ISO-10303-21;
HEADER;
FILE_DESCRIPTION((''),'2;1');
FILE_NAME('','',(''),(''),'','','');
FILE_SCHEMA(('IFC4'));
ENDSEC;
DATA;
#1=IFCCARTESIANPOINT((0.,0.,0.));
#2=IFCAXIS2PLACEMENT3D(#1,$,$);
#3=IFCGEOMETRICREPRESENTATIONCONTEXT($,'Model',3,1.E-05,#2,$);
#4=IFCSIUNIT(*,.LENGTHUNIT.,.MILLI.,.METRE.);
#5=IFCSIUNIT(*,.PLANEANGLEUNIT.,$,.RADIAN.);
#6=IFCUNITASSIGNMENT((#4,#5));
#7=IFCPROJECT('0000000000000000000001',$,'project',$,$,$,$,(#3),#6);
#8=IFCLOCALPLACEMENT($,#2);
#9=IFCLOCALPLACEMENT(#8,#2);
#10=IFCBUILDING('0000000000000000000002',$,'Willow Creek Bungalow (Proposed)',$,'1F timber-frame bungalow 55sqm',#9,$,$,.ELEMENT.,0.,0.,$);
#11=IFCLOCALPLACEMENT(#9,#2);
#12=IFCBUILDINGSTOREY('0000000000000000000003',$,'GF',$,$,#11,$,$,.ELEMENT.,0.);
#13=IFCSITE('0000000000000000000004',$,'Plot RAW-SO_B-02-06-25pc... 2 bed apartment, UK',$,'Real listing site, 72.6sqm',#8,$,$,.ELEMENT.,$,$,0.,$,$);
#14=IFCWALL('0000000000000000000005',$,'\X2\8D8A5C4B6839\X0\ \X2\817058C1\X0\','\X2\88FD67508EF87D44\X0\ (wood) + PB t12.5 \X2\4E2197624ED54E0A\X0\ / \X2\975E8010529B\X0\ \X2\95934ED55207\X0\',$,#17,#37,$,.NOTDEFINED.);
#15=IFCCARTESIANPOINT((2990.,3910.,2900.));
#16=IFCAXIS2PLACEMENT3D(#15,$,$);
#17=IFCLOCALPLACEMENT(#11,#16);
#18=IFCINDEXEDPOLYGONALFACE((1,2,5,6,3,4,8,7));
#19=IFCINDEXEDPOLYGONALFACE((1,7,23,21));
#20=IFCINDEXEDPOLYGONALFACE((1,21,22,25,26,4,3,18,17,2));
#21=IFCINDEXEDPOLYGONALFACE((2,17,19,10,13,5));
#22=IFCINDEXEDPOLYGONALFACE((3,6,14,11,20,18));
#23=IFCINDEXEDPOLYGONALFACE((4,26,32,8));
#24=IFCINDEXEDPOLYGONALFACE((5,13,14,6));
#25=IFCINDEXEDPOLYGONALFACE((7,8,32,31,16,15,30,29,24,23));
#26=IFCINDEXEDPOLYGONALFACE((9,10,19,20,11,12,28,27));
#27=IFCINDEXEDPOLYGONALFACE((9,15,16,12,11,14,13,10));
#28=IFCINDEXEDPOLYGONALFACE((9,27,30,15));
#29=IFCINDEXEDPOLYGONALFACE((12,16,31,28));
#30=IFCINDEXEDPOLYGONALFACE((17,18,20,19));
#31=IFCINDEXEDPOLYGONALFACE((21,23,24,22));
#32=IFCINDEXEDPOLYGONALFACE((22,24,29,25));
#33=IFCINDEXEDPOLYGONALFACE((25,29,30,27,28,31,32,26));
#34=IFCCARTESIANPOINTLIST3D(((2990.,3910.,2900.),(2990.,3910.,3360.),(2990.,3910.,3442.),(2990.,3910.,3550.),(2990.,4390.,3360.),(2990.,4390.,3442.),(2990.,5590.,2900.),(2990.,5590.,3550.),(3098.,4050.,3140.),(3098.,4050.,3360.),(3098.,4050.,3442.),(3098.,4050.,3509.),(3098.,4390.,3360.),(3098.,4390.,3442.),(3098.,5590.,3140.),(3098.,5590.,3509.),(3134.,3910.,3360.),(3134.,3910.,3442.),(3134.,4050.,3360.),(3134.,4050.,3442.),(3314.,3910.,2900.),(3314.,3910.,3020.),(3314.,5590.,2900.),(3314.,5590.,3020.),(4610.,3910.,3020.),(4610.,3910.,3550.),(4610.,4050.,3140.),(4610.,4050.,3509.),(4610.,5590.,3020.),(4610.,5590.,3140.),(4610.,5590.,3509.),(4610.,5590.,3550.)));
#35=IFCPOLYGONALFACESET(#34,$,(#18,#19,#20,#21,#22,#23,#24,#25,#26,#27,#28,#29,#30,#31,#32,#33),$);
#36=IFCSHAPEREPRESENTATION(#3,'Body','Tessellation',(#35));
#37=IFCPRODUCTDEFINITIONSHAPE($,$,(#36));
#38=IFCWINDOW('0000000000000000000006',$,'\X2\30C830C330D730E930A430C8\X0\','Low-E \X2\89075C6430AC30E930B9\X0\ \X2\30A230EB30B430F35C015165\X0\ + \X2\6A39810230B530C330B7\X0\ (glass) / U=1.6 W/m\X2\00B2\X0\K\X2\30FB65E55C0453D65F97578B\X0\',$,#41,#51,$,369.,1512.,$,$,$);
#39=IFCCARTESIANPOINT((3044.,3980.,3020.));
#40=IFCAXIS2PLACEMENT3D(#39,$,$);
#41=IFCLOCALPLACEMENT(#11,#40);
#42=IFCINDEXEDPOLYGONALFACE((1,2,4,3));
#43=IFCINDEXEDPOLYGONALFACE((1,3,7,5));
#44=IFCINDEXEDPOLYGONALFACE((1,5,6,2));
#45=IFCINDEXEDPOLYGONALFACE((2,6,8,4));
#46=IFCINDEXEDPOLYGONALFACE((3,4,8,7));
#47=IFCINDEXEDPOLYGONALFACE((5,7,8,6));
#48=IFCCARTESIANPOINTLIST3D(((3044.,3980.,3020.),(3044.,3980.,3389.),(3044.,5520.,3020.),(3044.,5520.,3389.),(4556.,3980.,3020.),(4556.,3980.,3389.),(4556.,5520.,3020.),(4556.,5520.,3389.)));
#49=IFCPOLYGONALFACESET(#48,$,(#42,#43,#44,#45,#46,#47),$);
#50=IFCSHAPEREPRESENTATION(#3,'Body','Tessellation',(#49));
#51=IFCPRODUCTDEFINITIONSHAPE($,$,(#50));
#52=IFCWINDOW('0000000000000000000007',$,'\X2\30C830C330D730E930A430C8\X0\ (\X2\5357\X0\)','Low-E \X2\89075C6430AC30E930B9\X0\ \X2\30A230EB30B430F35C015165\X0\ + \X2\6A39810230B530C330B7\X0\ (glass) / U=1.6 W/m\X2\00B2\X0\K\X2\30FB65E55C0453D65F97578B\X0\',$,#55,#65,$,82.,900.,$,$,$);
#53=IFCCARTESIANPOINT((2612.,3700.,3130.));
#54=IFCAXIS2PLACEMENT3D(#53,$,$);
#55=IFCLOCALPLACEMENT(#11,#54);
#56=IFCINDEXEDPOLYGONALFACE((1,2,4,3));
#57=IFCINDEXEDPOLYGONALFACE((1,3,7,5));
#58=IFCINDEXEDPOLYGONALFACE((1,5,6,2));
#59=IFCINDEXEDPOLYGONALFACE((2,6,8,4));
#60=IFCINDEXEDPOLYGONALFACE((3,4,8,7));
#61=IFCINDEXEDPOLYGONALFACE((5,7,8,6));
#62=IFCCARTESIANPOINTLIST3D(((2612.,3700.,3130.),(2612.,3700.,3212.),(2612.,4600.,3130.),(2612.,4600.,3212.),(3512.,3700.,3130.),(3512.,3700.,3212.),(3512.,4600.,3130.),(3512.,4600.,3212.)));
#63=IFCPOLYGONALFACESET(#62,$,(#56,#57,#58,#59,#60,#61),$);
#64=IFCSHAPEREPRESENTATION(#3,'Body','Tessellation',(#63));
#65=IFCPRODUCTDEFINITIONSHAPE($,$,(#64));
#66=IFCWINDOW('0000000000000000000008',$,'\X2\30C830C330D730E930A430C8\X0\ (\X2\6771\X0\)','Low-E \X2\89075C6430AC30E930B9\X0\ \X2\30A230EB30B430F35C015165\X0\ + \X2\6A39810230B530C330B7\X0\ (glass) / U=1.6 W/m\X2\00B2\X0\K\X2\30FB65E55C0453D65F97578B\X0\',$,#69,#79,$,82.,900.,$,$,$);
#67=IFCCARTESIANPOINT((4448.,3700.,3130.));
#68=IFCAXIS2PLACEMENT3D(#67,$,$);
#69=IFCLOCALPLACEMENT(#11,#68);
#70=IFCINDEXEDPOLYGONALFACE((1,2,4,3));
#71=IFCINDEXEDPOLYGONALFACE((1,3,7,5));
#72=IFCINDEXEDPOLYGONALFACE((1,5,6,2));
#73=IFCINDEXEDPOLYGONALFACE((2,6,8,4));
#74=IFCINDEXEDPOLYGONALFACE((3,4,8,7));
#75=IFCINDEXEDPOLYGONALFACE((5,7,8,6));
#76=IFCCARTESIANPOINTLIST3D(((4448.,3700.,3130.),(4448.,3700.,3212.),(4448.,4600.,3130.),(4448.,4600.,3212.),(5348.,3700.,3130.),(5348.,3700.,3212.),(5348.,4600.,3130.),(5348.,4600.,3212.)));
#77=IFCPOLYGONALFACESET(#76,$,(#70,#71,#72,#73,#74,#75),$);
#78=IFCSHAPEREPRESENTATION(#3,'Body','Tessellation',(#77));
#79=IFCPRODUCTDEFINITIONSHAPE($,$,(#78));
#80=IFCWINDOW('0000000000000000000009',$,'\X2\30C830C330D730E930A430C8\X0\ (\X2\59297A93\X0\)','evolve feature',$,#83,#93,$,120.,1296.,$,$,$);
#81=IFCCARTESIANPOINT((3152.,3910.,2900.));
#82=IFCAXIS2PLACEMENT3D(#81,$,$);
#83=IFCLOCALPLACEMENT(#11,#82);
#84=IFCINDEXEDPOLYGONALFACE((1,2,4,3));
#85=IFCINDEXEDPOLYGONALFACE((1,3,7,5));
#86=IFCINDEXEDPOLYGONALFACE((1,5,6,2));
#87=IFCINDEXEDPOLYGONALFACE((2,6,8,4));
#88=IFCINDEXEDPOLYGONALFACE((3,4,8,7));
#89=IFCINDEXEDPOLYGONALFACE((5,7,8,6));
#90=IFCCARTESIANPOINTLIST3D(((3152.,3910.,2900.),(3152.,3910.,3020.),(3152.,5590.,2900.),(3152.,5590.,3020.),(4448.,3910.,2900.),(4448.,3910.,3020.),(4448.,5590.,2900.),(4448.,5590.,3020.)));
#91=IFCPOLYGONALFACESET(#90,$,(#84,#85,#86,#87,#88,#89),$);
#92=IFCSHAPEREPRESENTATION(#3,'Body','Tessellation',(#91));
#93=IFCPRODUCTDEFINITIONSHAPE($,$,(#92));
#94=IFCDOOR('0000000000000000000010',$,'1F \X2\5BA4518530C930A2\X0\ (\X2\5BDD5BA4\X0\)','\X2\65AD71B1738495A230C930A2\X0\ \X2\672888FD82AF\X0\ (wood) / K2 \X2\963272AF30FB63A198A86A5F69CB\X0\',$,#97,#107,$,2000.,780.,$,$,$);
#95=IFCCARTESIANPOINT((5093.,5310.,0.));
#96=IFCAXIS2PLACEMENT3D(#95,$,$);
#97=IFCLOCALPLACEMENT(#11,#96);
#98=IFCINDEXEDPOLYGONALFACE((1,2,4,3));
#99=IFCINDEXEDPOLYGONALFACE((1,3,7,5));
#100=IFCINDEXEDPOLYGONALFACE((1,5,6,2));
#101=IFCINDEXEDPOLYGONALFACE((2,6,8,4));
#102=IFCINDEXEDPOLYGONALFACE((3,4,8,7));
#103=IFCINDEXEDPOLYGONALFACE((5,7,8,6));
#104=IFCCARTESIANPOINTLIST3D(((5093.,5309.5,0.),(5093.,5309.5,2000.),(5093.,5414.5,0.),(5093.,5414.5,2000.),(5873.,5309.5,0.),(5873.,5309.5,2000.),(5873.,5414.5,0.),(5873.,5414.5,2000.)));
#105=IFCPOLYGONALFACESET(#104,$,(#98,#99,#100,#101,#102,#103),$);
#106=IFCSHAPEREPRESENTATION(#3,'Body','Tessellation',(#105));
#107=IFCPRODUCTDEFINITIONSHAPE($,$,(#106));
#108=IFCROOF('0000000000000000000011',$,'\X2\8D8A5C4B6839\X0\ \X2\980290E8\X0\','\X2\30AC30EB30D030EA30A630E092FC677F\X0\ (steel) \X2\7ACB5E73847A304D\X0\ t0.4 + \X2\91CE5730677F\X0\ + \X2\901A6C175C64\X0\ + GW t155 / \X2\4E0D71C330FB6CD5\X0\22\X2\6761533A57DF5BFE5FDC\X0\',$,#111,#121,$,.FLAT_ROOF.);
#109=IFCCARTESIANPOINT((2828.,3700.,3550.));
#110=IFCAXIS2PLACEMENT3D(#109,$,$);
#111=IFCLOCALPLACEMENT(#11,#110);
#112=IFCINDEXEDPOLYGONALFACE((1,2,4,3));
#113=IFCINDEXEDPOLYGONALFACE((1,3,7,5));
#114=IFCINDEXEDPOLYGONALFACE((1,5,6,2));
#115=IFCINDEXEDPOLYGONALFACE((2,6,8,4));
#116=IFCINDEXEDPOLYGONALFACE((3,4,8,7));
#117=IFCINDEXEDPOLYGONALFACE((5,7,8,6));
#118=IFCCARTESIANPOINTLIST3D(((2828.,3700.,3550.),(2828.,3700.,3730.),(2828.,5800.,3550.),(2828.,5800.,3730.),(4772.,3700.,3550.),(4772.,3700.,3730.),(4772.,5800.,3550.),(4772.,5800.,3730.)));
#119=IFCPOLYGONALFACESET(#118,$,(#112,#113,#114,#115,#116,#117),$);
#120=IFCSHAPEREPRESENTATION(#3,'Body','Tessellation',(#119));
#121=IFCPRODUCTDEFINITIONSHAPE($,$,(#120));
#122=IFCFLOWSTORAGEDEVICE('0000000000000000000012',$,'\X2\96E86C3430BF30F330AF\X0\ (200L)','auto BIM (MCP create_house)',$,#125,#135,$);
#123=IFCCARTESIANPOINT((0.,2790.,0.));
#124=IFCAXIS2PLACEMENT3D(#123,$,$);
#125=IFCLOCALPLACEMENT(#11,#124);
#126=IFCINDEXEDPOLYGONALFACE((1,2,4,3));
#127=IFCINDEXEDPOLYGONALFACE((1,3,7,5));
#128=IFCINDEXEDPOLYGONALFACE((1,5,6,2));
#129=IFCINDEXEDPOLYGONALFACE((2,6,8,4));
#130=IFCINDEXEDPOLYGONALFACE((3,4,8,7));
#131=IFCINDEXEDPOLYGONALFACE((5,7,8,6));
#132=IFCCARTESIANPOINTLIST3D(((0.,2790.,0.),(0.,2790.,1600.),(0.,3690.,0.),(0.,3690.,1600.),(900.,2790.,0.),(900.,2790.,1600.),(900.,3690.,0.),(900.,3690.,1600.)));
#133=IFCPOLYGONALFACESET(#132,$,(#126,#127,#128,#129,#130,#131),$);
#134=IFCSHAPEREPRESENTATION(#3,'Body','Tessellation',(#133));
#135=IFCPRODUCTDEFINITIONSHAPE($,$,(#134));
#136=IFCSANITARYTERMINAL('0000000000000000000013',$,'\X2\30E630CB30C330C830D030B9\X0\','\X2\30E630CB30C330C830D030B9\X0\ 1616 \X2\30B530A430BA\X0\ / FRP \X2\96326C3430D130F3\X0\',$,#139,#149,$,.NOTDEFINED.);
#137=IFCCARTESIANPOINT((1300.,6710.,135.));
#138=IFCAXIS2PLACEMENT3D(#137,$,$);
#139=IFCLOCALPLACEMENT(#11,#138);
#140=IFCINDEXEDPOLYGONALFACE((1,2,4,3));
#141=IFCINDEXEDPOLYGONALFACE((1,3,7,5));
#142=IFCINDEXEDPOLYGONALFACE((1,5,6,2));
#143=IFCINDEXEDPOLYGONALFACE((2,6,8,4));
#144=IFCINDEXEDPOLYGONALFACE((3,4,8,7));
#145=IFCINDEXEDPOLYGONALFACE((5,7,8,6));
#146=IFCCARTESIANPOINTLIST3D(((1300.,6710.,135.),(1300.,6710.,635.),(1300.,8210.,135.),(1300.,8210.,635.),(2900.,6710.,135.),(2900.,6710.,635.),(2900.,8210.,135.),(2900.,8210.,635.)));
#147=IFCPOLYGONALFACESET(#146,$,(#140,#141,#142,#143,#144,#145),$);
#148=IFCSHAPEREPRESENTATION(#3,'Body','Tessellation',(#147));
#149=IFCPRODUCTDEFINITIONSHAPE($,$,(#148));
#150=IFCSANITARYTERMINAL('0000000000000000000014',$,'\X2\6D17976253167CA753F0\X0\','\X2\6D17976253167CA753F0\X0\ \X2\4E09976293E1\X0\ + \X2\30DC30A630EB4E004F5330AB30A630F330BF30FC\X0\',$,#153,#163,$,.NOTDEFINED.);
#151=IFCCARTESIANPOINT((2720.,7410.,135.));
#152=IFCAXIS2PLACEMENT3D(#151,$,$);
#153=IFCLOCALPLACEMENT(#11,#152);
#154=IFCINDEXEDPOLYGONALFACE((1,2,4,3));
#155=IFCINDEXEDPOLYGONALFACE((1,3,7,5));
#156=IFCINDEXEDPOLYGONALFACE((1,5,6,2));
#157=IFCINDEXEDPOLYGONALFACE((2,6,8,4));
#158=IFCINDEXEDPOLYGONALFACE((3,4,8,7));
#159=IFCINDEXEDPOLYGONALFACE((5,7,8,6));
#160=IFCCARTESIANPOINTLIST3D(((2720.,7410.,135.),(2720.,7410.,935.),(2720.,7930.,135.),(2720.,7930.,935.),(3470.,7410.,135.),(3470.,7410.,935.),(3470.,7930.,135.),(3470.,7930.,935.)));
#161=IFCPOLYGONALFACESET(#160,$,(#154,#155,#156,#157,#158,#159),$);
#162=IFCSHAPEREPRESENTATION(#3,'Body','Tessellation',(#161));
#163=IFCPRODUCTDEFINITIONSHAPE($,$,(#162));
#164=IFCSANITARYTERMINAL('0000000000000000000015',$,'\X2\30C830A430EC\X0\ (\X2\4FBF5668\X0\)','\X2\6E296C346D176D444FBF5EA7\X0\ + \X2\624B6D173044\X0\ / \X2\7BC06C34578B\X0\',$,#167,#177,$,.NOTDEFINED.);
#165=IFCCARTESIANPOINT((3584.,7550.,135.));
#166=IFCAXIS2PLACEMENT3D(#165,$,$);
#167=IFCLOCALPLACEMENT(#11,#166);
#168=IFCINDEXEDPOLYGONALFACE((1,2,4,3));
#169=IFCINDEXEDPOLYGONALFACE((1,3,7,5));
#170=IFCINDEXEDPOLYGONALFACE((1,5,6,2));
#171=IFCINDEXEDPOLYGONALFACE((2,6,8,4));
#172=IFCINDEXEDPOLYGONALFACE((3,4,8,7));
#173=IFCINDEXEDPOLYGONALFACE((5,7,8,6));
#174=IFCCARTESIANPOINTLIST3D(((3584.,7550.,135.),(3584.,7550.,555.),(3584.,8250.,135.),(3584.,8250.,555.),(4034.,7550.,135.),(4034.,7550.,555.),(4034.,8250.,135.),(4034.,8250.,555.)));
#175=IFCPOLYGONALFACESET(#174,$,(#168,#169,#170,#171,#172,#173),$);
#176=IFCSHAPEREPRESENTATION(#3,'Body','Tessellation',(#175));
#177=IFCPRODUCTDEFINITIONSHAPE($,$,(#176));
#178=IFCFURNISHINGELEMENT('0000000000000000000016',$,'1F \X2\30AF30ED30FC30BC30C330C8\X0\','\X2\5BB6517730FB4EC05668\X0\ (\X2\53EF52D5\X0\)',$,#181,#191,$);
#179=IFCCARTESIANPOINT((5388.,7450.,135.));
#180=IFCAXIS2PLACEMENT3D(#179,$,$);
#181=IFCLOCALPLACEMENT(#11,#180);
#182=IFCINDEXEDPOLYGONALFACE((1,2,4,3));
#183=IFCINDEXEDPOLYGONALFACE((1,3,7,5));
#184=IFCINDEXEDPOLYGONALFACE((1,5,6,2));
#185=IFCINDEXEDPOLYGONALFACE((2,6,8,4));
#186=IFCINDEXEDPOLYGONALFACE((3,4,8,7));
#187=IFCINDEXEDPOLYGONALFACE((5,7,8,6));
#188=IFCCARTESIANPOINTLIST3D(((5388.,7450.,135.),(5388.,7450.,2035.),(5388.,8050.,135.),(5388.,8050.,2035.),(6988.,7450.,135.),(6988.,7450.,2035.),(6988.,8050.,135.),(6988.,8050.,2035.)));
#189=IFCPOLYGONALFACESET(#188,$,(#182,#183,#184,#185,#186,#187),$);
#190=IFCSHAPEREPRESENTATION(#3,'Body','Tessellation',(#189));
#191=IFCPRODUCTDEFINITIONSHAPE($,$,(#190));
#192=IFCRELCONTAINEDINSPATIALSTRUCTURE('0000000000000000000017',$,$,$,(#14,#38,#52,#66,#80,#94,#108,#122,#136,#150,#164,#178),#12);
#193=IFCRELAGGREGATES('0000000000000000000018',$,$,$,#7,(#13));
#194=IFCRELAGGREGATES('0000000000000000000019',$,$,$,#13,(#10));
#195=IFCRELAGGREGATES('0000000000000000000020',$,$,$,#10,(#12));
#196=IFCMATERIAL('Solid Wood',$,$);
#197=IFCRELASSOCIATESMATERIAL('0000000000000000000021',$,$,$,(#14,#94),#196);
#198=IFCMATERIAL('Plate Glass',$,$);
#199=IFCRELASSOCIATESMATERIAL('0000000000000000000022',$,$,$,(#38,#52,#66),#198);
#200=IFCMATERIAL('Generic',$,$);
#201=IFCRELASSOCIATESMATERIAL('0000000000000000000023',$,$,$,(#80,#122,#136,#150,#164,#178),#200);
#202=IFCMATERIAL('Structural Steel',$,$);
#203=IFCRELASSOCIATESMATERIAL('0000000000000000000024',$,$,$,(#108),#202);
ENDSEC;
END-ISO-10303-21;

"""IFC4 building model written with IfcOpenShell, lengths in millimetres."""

from ifc_helpers import new_model, si_unit, frame, frame_2d, origin, place, context, project, spatial, rectangle, extrude, material, element, fill, save


model = new_model("IFC4")

# Units and contexts
model_context = context("Model", 3, precision=1e-05, world=origin())
ifc_project = project(units=[si_unit("LENGTHUNIT", "METRE", prefix="MILLI"), si_unit("PLANEANGLEUNIT", "RADIAN")], contexts=[model_context])

# Site, building, storey
site_placement = place(None, origin())
site = spatial("IfcSite", under=ifc_project, at=site_placement, Name="Plot RAW-SO_B-02-06-25pc... 2 bed apartment, UK", ObjectType="Real listing site, 72.6sqm", CompositionType="ELEMENT", RefElevation=0.0)
building_placement = place(site_placement, origin())
building = spatial("IfcBuilding", under=site, at=building_placement, Name="Willow Creek Bungalow (Proposed)", ObjectType="1F timber-frame bungalow 55sqm", CompositionType="ELEMENT", ElevationOfRefHeight=0.0, ElevationOfTerrain=0.0)
storey_placement = place(building_placement, origin())
storey = spatial("IfcBuildingStorey", under=building, at=storey_placement, Name="GF", CompositionType="ELEMENT", Elevation=0.0)

# Shared definitions
ifc_material_1 = material(Name="Solid Wood")

# Shared definitions
ifc_material_2 = material(Name="Plate Glass")

# Wall, openings, windows
wall_1_placement = place(storey_placement, frame((2990.0, 3910.0, 2900.0)))
wall_1 = element("IfcWall", 1, at=wall_1_placement, inside=storey, material=ifc_material_1, Name="越屋根 腰壁", Description="製材軸組 (wood) + PB t12.5 両面仕上 / 非耐力 間仕切", PredefinedType="NOTDEFINED", context=model_context, shape_type="SweptSolid", body=[
    extrude(rectangle(XDim=1620.0, YDim=1680.0, at=frame_2d((810.0, 840.0))), frame((2990.0, 3910.0, 2900.0)), (0.0, 0.0, 1.0), 650.0),
])
opening_1_placement = place(storey_placement, frame((3044.0, 3980.0, 3020.0)))
opening_1 = element("IfcOpeningElement", 2, at=opening_1_placement, cuts=wall_1, PredefinedType="NOTDEFINED", context=model_context, shape_type="SweptSolid", body=[
    extrude(rectangle(XDim=1512.0, YDim=1540.0, at=frame_2d((756.0, 770.0))), frame((3044.0, 3980.0, 3020.0)), (0.0, 0.0, 1.0), 369.0),
])
opening_2_placement = place(storey_placement, frame((2612.0, 3700.0, 3130.0)))
opening_2 = element("IfcOpeningElement", 3, at=opening_2_placement, cuts=wall_1, PredefinedType="NOTDEFINED", context=model_context, shape_type="SweptSolid", body=[
    extrude(rectangle(XDim=900.0, YDim=900.0, at=frame_2d((450.0, 450.0))), frame((2612.0, 3700.0, 3130.0)), (0.0, 0.0, 1.0), 82.0),
])
opening_3_placement = place(storey_placement, frame((4448.0, 3700.0, 3130.0)))
opening_3 = element("IfcOpeningElement", 4, at=opening_3_placement, cuts=wall_1, PredefinedType="NOTDEFINED", context=model_context, shape_type="SweptSolid", body=[
    extrude(rectangle(XDim=900.0, YDim=900.0, at=frame_2d((450.0, 450.0))), frame((4448.0, 3700.0, 3130.0)), (0.0, 0.0, 1.0), 82.0),
])
opening_4_placement = place(storey_placement, frame((3152.0, 3910.0, 2900.0)))
opening_4 = element("IfcOpeningElement", 5, at=opening_4_placement, cuts=wall_1, PredefinedType="NOTDEFINED", context=model_context, shape_type="SweptSolid", body=[
    extrude(rectangle(XDim=1296.0, YDim=1680.0, at=frame_2d((648.0, 840.0))), frame((3152.0, 3910.0, 2900.0)), (0.0, 0.0, 1.0), 120.0),
])
window_1_placement = place(storey_placement, frame((3044.0, 3980.0, 3020.0)))
window_1 = element("IfcWindow", 6, at=window_1_placement, inside=storey, material=ifc_material_2, Name="トップライト", Description="Low-E 複層ガラス アルゴン封入 + 樹脂サッシ (glass) / U=1.6 W/m²K・日射取得型", OverallHeight=369.0, OverallWidth=1512.0, context=model_context, shape_type="SweptSolid", body=[
    extrude(rectangle(XDim=1512.0, YDim=1540.0, at=frame_2d((756.0, 770.0))), frame((3044.0, 3980.0, 3020.0)), (0.0, 0.0, 1.0), 369.0),
])
fill(opening_1, window_1)
window_2_placement = place(storey_placement, frame((2612.0, 3700.0, 3130.0)))
window_2 = element("IfcWindow", 7, at=window_2_placement, inside=storey, material=ifc_material_2, Name="トップライト (南)", Description="Low-E 複層ガラス アルゴン封入 + 樹脂サッシ (glass) / U=1.6 W/m²K・日射取得型", OverallHeight=82.0, OverallWidth=900.0, context=model_context, shape_type="SweptSolid", body=[
    extrude(rectangle(XDim=900.0, YDim=900.0, at=frame_2d((450.0, 450.0))), frame((2612.0, 3700.0, 3130.0)), (0.0, 0.0, 1.0), 82.0),
])
fill(opening_2, window_2)
window_3_placement = place(storey_placement, frame((4448.0, 3700.0, 3130.0)))
window_3 = element("IfcWindow", 8, at=window_3_placement, inside=storey, material=ifc_material_2, Name="トップライト (東)", Description="Low-E 複層ガラス アルゴン封入 + 樹脂サッシ (glass) / U=1.6 W/m²K・日射取得型", OverallHeight=82.0, OverallWidth=900.0, context=model_context, shape_type="SweptSolid", body=[
    extrude(rectangle(XDim=900.0, YDim=900.0, at=frame_2d((450.0, 450.0))), frame((4448.0, 3700.0, 3130.0)), (0.0, 0.0, 1.0), 82.0),
])
fill(opening_3, window_3)
ifc_material_3 = material(Name="Generic")
window_4_placement = place(storey_placement, frame((3152.0, 3910.0, 2900.0)))
window_4 = element("IfcWindow", 9, at=window_4_placement, inside=storey, material=ifc_material_3, Name="トップライト (天窓)", Description="evolve feature", OverallHeight=120.0, OverallWidth=1296.0, context=model_context, shape_type="SweptSolid", body=[
    extrude(rectangle(XDim=1296.0, YDim=1680.0, at=frame_2d((648.0, 840.0))), frame((3152.0, 3910.0, 2900.0)), (0.0, 0.0, 1.0), 120.0),
])
fill(opening_4, window_4)

# Door
door_1_placement = place(storey_placement, frame((5093.0, 5310.0, 0.0)))
element("IfcDoor", 10, at=door_1_placement, inside=storey, material=ifc_material_1, Name="1F 室内ドア (寝室)", Description="断熱玄関ドア 木製芯 (wood) / K2 防犯・採風機構", OverallHeight=2000.0, OverallWidth=780.0, context=model_context, shape_type="SweptSolid", body=[
    extrude(rectangle(XDim=780.0, YDim=105.0, at=frame_2d((390.0, 52.0))), frame((5093.0, 5310.0, 0.0)), (0.0, 0.0, 1.0), 2000.0),
])

# Roof
ifc_material_4 = material(Name="Structural Steel")
roof_placement = place(storey_placement, frame((2828.0, 3700.0, 3550.0)))
element("IfcRoof", 11, at=roof_placement, inside=storey, material=ifc_material_4, Name="越屋根 頂部", Description="ガルバリウム鋼板 (steel) 立平葺き t0.4 + 野地板 + 通気層 + GW t155 / 不燃・法22条区域対応", PredefinedType="FLAT_ROOF", context=model_context, shape_type="SweptSolid", body=[
    extrude(rectangle(XDim=1944.0, YDim=2100.0, at=frame_2d((972.0, 1050.0))), frame((2828.0, 3700.0, 3550.0)), (0.0, 0.0, 1.0), 180.0),
])

# Flow storage device
flow_storage_device_placement = place(storey_placement, frame((0.0, 2790.0, 0.0)))
element("IfcFlowStorageDevice", 12, at=flow_storage_device_placement, inside=storey, material=ifc_material_3, Name="雨水タンク (200L)", Description="auto BIM (MCP create_house)", context=model_context, shape_type="SweptSolid", body=[
    extrude(rectangle(XDim=900.0, YDim=900.0, at=frame_2d((450.0, 450.0))), frame((0.0, 2790.0, 0.0)), (0.0, 0.0, 1.0), 1600.0),
])

# Sanitary terminals
sanitary_terminal_1_placement = place(storey_placement, frame((1300.0, 6710.0, 135.0)))
element("IfcSanitaryTerminal", 13, at=sanitary_terminal_1_placement, inside=storey, material=ifc_material_3, Name="ユニットバス", Description="ユニットバス 1616 サイズ / FRP 防水パン", PredefinedType="NOTDEFINED", context=model_context, shape_type="SweptSolid", body=[
    extrude(rectangle(XDim=1600.0, YDim=1500.0, at=frame_2d((800.0, 750.0))), frame((1300.0, 6710.0, 135.0)), (0.0, 0.0, 1.0), 500.0),
])
sanitary_terminal_2_placement = place(storey_placement, frame((2720.0, 7410.0, 135.0)))
element("IfcSanitaryTerminal", 14, at=sanitary_terminal_2_placement, inside=storey, material=ifc_material_3, Name="洗面化粧台", Description="洗面化粧台 三面鏡 + ボウル一体カウンター", PredefinedType="NOTDEFINED", context=model_context, shape_type="SweptSolid", body=[
    extrude(rectangle(XDim=750.0, YDim=520.0, at=frame_2d((375.0, 260.0))), frame((2720.0, 7410.0, 135.0)), (0.0, 0.0, 1.0), 800.0),
])
sanitary_terminal_3_placement = place(storey_placement, frame((3584.0, 7550.0, 135.0)))
element("IfcSanitaryTerminal", 15, at=sanitary_terminal_3_placement, inside=storey, material=ifc_material_3, Name="トイレ (便器)", Description="温水洗浄便座 + 手洗い / 節水型", PredefinedType="NOTDEFINED", context=model_context, shape_type="SweptSolid", body=[
    extrude(rectangle(XDim=450.0, YDim=700.0, at=frame_2d((225.0, 350.0))), frame((3584.0, 7550.0, 135.0)), (0.0, 0.0, 1.0), 420.0),
])

# Furnishing element
furnishing_1_placement = place(storey_placement, frame((5388.0, 7450.0, 135.0)))
element("IfcFurnishingElement", 16, at=furnishing_1_placement, inside=storey, material=ifc_material_3, Name="1F クローゼット", Description="家具・什器 (可動)", context=model_context, shape_type="SweptSolid", body=[
    extrude(rectangle(XDim=1600.0, YDim=600.0, at=frame_2d((800.0, 300.0))), frame((5388.0, 7450.0, 135.0)), (0.0, 0.0, 1.0), 1900.0),
])

save(model, "model.ifc")
